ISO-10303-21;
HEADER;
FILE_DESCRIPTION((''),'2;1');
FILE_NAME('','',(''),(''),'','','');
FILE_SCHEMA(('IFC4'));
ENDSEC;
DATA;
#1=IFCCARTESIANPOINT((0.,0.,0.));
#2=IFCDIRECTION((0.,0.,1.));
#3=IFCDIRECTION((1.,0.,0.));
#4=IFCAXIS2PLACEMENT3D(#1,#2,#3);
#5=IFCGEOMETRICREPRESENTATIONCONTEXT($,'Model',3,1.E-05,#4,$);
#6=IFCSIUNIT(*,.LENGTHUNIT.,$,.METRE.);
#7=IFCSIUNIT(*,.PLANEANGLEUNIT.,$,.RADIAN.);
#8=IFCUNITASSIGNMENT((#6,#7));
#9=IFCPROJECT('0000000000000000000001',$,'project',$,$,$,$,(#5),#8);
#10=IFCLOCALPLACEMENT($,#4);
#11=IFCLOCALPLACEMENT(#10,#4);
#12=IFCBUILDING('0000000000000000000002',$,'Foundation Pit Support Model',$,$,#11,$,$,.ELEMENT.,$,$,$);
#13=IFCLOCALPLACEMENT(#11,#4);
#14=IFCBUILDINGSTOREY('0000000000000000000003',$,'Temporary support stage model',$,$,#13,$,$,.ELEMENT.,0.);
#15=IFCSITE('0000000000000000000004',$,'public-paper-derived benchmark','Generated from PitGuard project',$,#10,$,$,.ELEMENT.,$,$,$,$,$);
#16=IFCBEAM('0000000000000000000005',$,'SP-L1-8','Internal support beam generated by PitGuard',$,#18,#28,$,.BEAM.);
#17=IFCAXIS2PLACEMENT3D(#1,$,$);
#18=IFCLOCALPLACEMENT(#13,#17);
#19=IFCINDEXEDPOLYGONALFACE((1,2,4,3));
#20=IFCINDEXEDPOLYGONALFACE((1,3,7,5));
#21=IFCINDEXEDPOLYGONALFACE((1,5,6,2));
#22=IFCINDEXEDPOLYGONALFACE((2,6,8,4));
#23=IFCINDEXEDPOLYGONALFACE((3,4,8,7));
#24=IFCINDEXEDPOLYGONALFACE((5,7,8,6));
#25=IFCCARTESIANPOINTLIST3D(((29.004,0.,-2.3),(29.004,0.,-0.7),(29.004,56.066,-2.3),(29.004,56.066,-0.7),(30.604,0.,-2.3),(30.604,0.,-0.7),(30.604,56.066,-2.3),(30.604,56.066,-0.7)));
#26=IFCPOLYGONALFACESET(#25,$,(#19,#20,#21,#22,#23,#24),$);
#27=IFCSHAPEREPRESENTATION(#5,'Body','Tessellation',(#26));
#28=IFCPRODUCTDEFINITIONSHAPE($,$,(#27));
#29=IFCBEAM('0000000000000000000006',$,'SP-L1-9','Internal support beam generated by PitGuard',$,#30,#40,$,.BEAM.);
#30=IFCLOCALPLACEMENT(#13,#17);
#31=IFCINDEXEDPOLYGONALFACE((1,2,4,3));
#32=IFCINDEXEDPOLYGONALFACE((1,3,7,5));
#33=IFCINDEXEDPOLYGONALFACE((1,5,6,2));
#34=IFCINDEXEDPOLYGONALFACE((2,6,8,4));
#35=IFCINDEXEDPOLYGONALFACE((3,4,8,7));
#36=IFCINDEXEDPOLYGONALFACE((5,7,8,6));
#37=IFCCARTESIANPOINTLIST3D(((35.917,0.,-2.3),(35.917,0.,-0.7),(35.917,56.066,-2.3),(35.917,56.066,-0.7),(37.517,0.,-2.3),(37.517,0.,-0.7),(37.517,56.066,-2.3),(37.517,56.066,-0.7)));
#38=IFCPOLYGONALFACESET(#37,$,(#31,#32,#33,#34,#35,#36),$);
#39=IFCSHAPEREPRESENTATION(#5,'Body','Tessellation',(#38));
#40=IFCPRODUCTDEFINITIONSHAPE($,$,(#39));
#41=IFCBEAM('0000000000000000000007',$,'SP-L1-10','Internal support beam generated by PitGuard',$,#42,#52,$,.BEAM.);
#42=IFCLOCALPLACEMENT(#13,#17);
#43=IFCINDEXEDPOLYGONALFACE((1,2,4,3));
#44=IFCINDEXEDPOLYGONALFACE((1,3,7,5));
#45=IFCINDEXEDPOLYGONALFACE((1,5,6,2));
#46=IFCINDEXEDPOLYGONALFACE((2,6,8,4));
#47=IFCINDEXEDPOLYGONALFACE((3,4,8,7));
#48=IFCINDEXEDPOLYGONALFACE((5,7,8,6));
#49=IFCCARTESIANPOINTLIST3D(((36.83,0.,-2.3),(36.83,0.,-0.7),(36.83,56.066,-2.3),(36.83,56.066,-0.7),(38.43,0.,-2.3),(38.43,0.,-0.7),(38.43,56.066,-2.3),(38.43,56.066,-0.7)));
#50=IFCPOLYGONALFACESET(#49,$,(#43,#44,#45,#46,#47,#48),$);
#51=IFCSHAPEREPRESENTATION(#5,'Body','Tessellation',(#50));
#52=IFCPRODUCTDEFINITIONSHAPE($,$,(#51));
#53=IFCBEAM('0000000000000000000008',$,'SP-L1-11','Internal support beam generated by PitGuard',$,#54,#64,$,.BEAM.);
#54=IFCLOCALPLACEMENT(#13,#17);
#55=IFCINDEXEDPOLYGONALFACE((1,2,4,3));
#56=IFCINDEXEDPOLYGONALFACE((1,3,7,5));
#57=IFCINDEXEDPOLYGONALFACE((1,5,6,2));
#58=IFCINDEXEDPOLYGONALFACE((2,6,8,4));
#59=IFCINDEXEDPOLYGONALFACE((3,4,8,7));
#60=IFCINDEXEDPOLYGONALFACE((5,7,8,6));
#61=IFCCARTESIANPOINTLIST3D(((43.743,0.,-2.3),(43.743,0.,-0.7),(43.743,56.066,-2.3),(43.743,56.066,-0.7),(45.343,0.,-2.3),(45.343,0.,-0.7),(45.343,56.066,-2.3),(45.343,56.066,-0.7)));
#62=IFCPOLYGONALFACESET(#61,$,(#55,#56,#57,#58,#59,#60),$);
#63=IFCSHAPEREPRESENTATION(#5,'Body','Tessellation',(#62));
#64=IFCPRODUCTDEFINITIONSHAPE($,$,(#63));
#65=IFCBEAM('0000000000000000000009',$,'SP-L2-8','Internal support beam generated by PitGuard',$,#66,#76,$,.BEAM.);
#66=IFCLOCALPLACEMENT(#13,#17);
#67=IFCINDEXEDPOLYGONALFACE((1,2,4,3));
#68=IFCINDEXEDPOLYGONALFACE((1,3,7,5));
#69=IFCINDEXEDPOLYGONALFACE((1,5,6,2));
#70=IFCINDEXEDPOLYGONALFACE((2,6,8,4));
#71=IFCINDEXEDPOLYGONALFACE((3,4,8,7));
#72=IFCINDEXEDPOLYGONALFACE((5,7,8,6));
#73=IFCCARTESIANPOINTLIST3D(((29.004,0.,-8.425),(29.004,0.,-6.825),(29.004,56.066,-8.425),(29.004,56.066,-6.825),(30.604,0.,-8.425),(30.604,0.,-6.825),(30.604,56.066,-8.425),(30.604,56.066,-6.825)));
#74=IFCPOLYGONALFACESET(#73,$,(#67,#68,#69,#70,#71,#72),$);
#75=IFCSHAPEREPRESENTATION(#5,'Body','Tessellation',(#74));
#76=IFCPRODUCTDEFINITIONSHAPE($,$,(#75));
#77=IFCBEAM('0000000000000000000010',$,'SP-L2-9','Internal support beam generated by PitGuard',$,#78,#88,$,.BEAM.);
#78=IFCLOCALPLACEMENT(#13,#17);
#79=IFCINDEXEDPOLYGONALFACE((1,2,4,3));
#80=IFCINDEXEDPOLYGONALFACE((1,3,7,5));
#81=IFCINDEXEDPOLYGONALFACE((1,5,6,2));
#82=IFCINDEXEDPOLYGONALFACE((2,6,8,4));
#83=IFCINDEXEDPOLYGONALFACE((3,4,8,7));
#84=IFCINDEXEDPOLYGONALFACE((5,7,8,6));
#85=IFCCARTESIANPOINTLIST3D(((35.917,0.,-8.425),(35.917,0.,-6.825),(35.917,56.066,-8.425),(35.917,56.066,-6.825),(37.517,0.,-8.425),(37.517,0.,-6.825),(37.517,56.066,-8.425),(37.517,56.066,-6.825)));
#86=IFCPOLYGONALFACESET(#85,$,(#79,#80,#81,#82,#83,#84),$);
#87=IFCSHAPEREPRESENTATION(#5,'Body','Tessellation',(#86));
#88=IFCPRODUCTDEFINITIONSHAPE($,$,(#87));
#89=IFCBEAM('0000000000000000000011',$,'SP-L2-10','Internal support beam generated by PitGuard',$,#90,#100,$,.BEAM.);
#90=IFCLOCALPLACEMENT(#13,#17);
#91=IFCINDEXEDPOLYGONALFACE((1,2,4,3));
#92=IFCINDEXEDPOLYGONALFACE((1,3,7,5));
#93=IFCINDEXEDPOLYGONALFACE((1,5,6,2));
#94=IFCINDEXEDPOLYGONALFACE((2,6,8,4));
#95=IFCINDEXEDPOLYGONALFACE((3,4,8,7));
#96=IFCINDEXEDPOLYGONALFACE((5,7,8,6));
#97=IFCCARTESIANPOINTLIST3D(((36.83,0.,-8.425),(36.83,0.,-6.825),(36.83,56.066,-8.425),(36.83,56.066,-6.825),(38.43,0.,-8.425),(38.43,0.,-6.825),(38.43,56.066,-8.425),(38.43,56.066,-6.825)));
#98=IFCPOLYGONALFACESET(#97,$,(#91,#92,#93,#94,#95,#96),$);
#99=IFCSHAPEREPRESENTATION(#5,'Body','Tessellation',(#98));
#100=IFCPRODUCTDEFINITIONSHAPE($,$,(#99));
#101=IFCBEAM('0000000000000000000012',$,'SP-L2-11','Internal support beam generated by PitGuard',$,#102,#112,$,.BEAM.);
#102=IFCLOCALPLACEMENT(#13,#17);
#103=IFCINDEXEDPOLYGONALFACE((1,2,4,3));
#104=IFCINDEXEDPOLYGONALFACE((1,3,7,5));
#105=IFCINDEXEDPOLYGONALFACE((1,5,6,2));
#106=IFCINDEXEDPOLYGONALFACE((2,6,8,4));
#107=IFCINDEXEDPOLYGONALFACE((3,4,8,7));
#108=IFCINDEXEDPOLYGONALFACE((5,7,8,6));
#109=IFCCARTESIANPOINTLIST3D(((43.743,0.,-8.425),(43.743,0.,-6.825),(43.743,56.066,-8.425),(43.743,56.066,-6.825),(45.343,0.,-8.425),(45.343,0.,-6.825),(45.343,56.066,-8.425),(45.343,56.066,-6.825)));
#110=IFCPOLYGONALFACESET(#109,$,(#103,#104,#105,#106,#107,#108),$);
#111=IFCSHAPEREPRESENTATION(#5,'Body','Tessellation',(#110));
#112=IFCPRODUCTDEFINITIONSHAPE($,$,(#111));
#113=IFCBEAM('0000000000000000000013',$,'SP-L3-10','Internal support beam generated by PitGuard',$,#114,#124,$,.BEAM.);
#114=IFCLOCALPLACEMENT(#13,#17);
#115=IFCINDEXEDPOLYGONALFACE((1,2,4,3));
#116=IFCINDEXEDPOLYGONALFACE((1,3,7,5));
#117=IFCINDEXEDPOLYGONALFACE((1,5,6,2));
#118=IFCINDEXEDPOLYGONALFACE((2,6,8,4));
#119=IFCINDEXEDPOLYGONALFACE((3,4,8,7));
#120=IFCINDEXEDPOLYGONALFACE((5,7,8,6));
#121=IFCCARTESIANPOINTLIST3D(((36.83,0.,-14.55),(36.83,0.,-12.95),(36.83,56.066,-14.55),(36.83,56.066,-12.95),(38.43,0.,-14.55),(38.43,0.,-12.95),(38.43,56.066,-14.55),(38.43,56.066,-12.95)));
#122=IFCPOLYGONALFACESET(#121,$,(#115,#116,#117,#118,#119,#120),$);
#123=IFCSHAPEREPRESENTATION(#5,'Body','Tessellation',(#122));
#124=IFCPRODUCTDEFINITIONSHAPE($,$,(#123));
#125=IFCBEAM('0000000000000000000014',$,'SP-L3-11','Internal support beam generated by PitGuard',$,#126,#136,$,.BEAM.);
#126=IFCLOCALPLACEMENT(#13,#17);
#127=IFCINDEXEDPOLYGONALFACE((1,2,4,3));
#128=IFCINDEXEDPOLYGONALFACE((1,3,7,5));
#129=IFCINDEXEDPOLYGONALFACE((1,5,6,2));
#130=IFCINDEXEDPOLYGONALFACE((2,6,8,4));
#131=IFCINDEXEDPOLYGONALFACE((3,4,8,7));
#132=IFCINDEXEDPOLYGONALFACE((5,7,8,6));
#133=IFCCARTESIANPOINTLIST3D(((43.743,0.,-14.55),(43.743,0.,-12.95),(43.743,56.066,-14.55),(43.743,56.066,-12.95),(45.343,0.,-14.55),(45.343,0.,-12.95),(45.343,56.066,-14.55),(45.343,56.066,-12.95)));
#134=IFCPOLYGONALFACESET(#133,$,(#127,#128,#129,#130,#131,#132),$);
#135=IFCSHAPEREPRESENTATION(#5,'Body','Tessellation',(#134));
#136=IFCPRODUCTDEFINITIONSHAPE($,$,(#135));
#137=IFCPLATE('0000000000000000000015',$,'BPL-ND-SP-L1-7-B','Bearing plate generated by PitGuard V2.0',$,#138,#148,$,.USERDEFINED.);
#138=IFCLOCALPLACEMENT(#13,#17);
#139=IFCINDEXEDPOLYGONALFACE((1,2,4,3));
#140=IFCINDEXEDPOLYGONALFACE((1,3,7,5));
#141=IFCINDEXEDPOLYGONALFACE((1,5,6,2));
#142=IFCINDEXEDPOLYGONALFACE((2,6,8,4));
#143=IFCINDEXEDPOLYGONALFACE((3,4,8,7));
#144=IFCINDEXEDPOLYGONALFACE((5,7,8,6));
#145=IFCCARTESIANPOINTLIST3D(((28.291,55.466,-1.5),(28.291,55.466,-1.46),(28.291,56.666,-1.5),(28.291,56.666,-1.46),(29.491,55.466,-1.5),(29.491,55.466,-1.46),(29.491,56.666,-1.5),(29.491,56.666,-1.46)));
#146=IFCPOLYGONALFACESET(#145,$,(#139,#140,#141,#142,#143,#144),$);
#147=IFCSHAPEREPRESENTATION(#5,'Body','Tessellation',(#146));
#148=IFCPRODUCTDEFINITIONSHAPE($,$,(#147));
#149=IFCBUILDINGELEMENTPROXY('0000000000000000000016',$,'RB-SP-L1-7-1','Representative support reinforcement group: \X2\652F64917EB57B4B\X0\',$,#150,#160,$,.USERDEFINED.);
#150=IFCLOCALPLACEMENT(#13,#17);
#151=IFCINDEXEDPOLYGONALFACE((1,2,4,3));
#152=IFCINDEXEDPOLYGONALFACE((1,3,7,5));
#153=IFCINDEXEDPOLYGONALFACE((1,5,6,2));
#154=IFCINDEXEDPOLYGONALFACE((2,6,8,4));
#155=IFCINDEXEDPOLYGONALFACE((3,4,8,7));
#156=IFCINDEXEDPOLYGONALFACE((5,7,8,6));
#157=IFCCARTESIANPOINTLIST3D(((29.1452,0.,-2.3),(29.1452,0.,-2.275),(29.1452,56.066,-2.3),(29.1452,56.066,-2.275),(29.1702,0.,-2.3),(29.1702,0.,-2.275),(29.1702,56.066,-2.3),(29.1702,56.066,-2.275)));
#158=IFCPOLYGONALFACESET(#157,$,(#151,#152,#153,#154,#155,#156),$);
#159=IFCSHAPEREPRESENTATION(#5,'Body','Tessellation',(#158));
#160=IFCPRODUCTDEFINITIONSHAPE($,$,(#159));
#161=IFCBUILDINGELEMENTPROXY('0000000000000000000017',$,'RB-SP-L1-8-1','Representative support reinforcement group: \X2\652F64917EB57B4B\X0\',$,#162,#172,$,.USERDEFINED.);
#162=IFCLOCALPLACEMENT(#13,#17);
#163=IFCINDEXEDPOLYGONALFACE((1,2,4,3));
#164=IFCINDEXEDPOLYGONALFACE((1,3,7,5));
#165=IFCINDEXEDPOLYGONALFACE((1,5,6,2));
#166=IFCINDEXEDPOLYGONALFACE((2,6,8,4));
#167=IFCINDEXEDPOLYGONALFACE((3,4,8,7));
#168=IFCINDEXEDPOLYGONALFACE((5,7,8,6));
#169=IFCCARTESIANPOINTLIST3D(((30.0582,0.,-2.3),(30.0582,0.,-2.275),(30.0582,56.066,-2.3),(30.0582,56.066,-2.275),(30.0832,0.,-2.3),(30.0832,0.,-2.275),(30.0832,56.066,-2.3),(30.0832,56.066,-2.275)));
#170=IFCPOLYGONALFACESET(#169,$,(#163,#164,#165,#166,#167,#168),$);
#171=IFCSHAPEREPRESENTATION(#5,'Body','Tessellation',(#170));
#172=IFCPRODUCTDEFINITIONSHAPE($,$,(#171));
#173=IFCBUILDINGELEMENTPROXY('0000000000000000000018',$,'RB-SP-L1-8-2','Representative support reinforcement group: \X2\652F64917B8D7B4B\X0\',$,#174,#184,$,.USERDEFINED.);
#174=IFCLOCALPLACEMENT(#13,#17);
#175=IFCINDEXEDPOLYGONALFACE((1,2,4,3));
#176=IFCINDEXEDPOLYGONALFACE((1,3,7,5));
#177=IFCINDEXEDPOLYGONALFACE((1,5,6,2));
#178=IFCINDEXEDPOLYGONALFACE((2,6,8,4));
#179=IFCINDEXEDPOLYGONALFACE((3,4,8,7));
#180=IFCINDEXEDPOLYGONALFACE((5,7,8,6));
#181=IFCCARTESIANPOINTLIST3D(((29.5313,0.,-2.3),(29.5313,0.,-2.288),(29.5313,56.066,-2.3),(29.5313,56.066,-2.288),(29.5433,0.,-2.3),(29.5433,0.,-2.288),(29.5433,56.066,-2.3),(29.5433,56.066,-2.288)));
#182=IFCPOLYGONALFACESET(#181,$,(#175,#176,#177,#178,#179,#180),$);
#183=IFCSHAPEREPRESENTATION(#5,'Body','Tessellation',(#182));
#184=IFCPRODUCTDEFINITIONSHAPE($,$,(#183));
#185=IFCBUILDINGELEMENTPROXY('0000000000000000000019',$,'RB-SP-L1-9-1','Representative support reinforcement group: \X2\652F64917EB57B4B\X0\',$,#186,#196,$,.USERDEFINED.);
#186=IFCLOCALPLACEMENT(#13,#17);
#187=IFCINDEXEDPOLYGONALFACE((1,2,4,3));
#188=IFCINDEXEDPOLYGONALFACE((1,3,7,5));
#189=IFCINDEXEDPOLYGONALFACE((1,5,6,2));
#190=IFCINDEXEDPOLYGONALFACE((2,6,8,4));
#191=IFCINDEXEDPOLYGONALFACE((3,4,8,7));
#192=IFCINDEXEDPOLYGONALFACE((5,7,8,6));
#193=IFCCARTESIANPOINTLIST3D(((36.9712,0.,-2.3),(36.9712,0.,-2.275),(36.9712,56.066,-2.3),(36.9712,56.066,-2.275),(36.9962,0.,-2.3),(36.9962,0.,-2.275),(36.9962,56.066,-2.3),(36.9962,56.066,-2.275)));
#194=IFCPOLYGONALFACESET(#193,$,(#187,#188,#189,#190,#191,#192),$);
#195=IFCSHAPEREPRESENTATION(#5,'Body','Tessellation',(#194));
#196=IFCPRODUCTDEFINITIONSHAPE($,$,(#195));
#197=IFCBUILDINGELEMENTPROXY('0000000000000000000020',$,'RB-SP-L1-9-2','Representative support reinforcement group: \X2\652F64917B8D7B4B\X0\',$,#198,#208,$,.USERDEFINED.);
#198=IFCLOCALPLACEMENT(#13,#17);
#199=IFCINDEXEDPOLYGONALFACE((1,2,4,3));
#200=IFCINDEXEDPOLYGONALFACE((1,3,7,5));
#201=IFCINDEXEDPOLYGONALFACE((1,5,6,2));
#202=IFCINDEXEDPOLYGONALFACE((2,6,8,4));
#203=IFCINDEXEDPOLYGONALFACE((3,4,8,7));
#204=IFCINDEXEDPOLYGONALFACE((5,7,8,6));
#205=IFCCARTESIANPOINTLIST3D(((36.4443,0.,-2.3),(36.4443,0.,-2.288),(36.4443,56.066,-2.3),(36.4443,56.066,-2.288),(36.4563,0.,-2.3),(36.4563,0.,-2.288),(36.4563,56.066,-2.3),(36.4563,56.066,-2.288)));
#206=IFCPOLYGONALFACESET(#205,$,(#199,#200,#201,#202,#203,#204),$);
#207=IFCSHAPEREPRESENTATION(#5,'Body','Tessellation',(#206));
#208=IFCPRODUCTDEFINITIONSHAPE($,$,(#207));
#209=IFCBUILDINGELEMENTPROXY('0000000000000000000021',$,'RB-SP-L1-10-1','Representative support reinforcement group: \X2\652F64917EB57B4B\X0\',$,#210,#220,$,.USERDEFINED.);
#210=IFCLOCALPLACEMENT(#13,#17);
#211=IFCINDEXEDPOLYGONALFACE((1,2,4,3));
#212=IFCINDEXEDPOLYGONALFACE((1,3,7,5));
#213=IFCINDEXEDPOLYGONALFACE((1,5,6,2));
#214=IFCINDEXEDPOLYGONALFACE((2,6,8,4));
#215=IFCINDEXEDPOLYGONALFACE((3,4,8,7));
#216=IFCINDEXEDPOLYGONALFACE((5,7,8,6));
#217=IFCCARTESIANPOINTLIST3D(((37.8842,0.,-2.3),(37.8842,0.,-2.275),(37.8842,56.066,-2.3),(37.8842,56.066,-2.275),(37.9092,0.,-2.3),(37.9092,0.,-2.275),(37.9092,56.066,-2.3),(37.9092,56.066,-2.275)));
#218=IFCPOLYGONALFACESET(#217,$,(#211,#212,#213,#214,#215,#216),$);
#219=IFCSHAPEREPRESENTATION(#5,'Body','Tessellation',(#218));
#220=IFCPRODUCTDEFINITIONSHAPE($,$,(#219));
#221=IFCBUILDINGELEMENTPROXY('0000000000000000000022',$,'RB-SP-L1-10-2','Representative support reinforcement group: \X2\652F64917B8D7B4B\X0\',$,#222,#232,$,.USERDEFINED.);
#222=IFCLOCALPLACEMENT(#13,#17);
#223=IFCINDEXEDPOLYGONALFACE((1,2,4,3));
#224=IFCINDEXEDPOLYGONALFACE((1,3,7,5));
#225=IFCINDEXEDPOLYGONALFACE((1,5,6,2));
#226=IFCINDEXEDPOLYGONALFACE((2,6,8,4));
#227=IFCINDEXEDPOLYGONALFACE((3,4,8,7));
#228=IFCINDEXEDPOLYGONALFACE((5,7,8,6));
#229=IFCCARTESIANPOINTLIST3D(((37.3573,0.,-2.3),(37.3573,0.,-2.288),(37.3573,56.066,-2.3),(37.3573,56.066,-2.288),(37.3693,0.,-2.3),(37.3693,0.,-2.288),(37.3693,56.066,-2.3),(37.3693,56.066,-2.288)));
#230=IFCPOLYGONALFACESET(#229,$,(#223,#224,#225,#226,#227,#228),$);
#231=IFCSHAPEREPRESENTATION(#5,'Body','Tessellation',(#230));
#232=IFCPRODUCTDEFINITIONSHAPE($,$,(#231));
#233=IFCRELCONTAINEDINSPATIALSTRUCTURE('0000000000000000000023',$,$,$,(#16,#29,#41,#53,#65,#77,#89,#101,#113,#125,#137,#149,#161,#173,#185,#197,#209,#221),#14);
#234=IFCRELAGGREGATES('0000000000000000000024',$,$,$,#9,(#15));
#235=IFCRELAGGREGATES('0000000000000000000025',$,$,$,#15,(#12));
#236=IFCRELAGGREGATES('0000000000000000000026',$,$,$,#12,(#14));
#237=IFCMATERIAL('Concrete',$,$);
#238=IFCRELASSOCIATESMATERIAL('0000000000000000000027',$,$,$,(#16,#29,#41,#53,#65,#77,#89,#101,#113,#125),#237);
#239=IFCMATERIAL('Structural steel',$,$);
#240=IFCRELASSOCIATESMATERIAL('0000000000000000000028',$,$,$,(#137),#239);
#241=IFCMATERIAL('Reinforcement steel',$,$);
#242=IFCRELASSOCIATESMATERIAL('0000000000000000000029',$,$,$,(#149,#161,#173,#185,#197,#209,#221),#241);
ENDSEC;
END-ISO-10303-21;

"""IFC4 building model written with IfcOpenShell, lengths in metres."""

from ifc_helpers import new_model, si_unit, frame, origin_with_axes, origin_2d, place, context, project, spatial, rectangle, extrude, material, element, save


model = new_model("IFC4")

# Units and contexts
model_context = context("Model", 3, precision=1e-05, world=origin_with_axes())
ifc_project = project(units=[si_unit("LENGTHUNIT", "METRE"), si_unit("PLANEANGLEUNIT", "RADIAN")], contexts=[model_context])

# Site, building, storey
site_placement = place(None, origin_with_axes())
site = spatial("IfcSite", under=ifc_project, at=site_placement, Name="public-paper-derived benchmark", Description="Generated from PitGuard project", CompositionType="ELEMENT")
building_placement = place(site_placement, origin_with_axes())
building = spatial("IfcBuilding", under=site, at=building_placement, Name="Foundation Pit Support Model", CompositionType="ELEMENT")
storey_placement = place(building_placement, origin_with_axes())
storey = spatial("IfcBuildingStorey", under=building, at=storey_placement, Name="Temporary support stage model", CompositionType="ELEMENT", Elevation=0.0)

# Beams
ifc_material_1 = material(Name="Concrete")
for number, where, z_axis, x_axis, name in (
    (1, (29.804, 28.033, -2.3), (0.0, 0.0, 1.0), (0.0, 1.0, 0.0), "SP-L1-8"),
    (2, (36.717, 28.033, -2.3), (0.0, 0.0, 1.0), (0.0, 1.0, 0.0), "SP-L1-9"),
    (3, (37.63, 28.033, -2.3), (0.0, 0.0, 1.0), (0.0, 1.0, 0.0), "SP-L1-10"),
    (4, (44.543, 28.033, -2.3), (0.0, 0.0, 1.0), (0.0, 1.0, 0.0), "SP-L1-11"),
    (5, (29.804, 28.033, -8.425), (0.0, 0.0, 1.0), (0.0, 1.0, 0.0), "SP-L2-8"),
    (6, (36.717, 28.033, -8.425), (0.0, 0.0, 1.0), (0.0, 1.0, 0.0), "SP-L2-9"),
    (7, (37.63, 28.033, -8.425), (0.0, 0.0, 1.0), (0.0, 1.0, 0.0), "SP-L2-10"),
    (8, (44.543, 28.033, -8.425), (0.0, 0.0, 1.0), (0.0, 1.0, 0.0), "SP-L2-11"),
    (9, (37.63, 28.033, -14.55), (0.0, 0.0, 1.0), (0.0, 1.0, 0.0), "SP-L3-10"),
    (10, (44.543, 28.033, -14.55), (0.0, 0.0, 1.0), (0.0, 1.0, 0.0), "SP-L3-11"),
):
    element("IfcBeam", number, at=place(storey_placement, frame(where, z_axis=z_axis, x_axis=x_axis)), inside=storey, material=ifc_material_1, Name=name, Description="Internal support beam generated by PitGuard", PredefinedType="BEAM", context=model_context, shape_type="SweptSolid", body=[
        extrude(rectangle(XDim=56.066, YDim=1.6, at=origin_2d()), origin_with_axes(), (0.0, 0.0, 1.0), 1.6),
    ])

# Plate
ifc_material_2 = material(Name="Structural steel")
plate_placement = place(storey_placement, frame((28.891, 56.066, -1.5), z_axis=(0.0, 0.0, 1.0), x_axis=(1.0, 0.0, 0.0)))
element("IfcPlate", 11, at=plate_placement, inside=storey, material=ifc_material_2, Name="BPL-ND-SP-L1-7-B", Description="Bearing plate generated by PitGuard V2.0", PredefinedType="USERDEFINED", context=model_context, shape_type="SweptSolid", body=[
    extrude(rectangle(XDim=1.2, YDim=1.2, at=origin_2d()), origin_with_axes(), (0.0, 0.0, 1.0), 0.04),
])

# Building element proxies
ifc_material_3 = material(Name="Reinforcement steel")
for number, where, z_axis, x_axis, name in (
    (12, (29.1577, 28.033, -2.3), (0.0, 0.0, 1.0), (0.0, 1.0, 0.0), "RB-SP-L1-7-1"),
    (13, (30.0707, 28.033, -2.3), (0.0, 0.0, 1.0), (0.0, 1.0, 0.0), "RB-SP-L1-8-1"),
):
    element("IfcBuildingElementProxy", number, at=place(storey_placement, frame(where, z_axis=z_axis, x_axis=x_axis)), inside=storey, material=ifc_material_3, Name=name, Description="Representative support reinforcement group: 支撑纵筋", PredefinedType="USERDEFINED", context=model_context, shape_type="SweptSolid", body=[
        extrude(rectangle(XDim=56.066, YDim=0.025, at=origin_2d()), origin_with_axes(), (0.0, 0.0, 1.0), 0.025),
    ])
proxy_1_placement = place(storey_placement, frame((29.5373, 28.033, -2.3), z_axis=(0.0, 0.0, 1.0), x_axis=(0.0, 1.0, 0.0)))
element("IfcBuildingElementProxy", 14, at=proxy_1_placement, inside=storey, material=ifc_material_3, Name="RB-SP-L1-8-2", Description="Representative support reinforcement group: 支撑箍筋", PredefinedType="USERDEFINED", context=model_context, shape_type="SweptSolid", body=[
    extrude(rectangle(XDim=56.066, YDim=0.012, at=origin_2d()), origin_with_axes(), (0.0, 0.0, 1.0), 0.012),
])
proxy_2_placement = place(storey_placement, frame((36.9837, 28.033, -2.3), z_axis=(0.0, 0.0, 1.0), x_axis=(0.0, 1.0, 0.0)))
element("IfcBuildingElementProxy", 15, at=proxy_2_placement, inside=storey, material=ifc_material_3, Name="RB-SP-L1-9-1", Description="Representative support reinforcement group: 支撑纵筋", PredefinedType="USERDEFINED", context=model_context, shape_type="SweptSolid", body=[
    extrude(rectangle(XDim=56.066, YDim=0.025, at=origin_2d()), origin_with_axes(), (0.0, 0.0, 1.0), 0.025),
])
proxy_3_placement = place(storey_placement, frame((36.4503, 28.033, -2.3), z_axis=(0.0, 0.0, 1.0), x_axis=(0.0, 1.0, 0.0)))
element("IfcBuildingElementProxy", 16, at=proxy_3_placement, inside=storey, material=ifc_material_3, Name="RB-SP-L1-9-2", Description="Representative support reinforcement group: 支撑箍筋", PredefinedType="USERDEFINED", context=model_context, shape_type="SweptSolid", body=[
    extrude(rectangle(XDim=56.066, YDim=0.012, at=origin_2d()), origin_with_axes(), (0.0, 0.0, 1.0), 0.012),
])
proxy_4_placement = place(storey_placement, frame((37.8967, 28.033, -2.3), z_axis=(0.0, 0.0, 1.0), x_axis=(0.0, 1.0, 0.0)))
element("IfcBuildingElementProxy", 17, at=proxy_4_placement, inside=storey, material=ifc_material_3, Name="RB-SP-L1-10-1", Description="Representative support reinforcement group: 支撑纵筋", PredefinedType="USERDEFINED", context=model_context, shape_type="SweptSolid", body=[
    extrude(rectangle(XDim=56.066, YDim=0.025, at=origin_2d()), origin_with_axes(), (0.0, 0.0, 1.0), 0.025),
])
proxy_5_placement = place(storey_placement, frame((37.3633, 28.033, -2.3), z_axis=(0.0, 0.0, 1.0), x_axis=(0.0, 1.0, 0.0)))
element("IfcBuildingElementProxy", 18, at=proxy_5_placement, inside=storey, material=ifc_material_3, Name="RB-SP-L1-10-2", Description="Representative support reinforcement group: 支撑箍筋", PredefinedType="USERDEFINED", context=model_context, shape_type="SweptSolid", body=[
    extrude(rectangle(XDim=56.066, YDim=0.012, at=origin_2d()), origin_with_axes(), (0.0, 0.0, 1.0), 0.012),
])

save(model, "model.ifc")
